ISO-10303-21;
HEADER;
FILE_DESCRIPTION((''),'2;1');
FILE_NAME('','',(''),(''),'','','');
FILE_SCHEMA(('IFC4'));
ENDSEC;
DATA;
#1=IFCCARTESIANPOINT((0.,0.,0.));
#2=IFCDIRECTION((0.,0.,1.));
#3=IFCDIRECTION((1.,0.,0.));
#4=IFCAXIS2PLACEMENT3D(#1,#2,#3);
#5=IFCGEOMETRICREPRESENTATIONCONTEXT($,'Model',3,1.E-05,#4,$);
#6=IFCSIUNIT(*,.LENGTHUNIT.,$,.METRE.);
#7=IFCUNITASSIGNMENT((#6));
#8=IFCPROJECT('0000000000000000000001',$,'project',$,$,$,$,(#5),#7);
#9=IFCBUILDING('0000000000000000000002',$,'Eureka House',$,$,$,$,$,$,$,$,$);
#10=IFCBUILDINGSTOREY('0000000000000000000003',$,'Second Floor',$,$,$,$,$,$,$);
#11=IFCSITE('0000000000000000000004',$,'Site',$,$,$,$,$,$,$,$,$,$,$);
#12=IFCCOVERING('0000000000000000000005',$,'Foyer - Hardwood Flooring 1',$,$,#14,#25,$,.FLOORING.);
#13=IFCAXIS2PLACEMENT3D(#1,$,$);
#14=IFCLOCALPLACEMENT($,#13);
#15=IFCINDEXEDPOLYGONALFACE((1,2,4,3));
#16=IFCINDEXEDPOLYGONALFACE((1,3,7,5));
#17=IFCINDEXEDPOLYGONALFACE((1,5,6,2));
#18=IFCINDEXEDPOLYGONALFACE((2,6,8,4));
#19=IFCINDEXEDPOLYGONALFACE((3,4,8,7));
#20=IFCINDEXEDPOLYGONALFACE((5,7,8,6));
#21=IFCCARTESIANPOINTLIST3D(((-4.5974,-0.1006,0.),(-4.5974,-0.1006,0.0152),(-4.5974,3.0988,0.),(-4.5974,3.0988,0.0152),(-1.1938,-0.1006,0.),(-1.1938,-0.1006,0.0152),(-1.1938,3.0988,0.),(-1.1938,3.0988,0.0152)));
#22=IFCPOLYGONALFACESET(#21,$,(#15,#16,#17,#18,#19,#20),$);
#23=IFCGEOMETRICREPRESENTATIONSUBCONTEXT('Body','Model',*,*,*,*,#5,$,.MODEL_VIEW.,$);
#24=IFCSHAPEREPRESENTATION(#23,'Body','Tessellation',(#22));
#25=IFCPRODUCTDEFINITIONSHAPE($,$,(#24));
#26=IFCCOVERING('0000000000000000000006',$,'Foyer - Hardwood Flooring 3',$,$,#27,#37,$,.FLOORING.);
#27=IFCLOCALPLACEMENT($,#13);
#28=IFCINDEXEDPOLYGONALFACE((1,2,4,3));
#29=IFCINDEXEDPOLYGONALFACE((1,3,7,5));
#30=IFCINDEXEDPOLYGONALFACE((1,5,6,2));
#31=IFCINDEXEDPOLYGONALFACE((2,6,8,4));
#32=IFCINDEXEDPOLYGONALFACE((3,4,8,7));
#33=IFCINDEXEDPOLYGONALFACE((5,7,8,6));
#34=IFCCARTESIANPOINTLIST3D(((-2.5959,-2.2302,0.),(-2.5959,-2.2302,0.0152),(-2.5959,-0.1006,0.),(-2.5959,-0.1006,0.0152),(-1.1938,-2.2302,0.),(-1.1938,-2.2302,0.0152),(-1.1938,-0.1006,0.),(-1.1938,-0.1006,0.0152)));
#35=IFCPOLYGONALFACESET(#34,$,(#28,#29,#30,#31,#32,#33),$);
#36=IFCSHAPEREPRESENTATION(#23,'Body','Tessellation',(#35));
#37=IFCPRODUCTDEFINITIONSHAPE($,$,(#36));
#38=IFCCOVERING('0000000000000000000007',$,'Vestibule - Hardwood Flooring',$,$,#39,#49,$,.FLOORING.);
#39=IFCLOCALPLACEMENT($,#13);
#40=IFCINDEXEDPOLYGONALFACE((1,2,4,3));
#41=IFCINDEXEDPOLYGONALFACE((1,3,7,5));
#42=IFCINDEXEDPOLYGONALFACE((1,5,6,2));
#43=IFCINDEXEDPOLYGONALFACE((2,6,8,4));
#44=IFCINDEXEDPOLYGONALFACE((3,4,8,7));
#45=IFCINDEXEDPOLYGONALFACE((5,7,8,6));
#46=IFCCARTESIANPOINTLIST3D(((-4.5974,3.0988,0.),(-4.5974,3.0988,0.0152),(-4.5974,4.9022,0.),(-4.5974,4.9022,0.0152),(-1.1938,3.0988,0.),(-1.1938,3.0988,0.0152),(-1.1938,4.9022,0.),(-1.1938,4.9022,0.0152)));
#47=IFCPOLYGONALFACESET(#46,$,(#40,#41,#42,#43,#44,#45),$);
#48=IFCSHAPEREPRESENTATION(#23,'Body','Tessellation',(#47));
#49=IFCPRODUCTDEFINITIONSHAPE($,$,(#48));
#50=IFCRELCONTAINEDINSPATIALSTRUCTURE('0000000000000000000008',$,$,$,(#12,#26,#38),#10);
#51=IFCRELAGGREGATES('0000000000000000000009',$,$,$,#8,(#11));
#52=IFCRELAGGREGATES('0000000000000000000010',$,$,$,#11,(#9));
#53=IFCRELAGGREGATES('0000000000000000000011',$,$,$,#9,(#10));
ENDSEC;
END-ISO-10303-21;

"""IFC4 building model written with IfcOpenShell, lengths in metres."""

from ifc_helpers import new_model, si_unit, frame, origin, origin_with_axes, origin_2d, place, context, subcontext, project, spatial, rectangle, extrude, element, save


model = new_model("IFC4")

# Units and contexts
model_context = context("Model", 3, precision=1e-05, world=origin_with_axes())
body_context = subcontext(model_context, "Body", "Model", "MODEL_VIEW")
ifc_project = project(units=[si_unit("LENGTHUNIT", "METRE")], contexts=[model_context])

# Site, building, storey
site = spatial("IfcSite", under=ifc_project, Name="Site")
building = spatial("IfcBuilding", under=site, Name="Eureka House")
storey = spatial("IfcBuildingStorey", under=building, Name="Second Floor")

# Coverings
covering_1_placement = place(None, frame((-2.8956, 1.4991, 0.0), z_axis=(0.0, 0.0, 1.0), x_axis=(1.0, 0.0, 0.0)))
element("IfcCovering", 1, at=covering_1_placement, inside=storey, Name="Foyer - Hardwood Flooring 1", PredefinedType="FLOORING", context=body_context, shape_type="SweptSolid", body=[
    extrude(rectangle(XDim=3.4036, YDim=3.1994, at=origin_2d()), origin(), (0.0, 0.0, 1.0), 0.0152),
])
covering_2_placement = place(None, frame((-1.8949, -1.1654, 0.0), z_axis=(0.0, 0.0, 1.0), x_axis=(1.0, 0.0, 0.0)))
element("IfcCovering", 2, at=covering_2_placement, inside=storey, Name="Foyer - Hardwood Flooring 3", PredefinedType="FLOORING", context=body_context, shape_type="SweptSolid", body=[
    extrude(rectangle(XDim=1.4021, YDim=2.1296, at=origin_2d()), origin(), (0.0, 0.0, 1.0), 0.0152),
])
covering_3_placement = place(None, frame((-2.8956, 4.0005, 0.0), z_axis=(0.0, 0.0, 1.0), x_axis=(1.0, 0.0, 0.0)))
element("IfcCovering", 3, at=covering_3_placement, inside=storey, Name="Vestibule - Hardwood Flooring", PredefinedType="FLOORING", context=body_context, shape_type="SweptSolid", body=[
    extrude(rectangle(XDim=3.4036, YDim=1.8034, at=origin_2d()), origin(), (0.0, 0.0, 1.0), 0.0152),
])

save(model, "model.ifc")
